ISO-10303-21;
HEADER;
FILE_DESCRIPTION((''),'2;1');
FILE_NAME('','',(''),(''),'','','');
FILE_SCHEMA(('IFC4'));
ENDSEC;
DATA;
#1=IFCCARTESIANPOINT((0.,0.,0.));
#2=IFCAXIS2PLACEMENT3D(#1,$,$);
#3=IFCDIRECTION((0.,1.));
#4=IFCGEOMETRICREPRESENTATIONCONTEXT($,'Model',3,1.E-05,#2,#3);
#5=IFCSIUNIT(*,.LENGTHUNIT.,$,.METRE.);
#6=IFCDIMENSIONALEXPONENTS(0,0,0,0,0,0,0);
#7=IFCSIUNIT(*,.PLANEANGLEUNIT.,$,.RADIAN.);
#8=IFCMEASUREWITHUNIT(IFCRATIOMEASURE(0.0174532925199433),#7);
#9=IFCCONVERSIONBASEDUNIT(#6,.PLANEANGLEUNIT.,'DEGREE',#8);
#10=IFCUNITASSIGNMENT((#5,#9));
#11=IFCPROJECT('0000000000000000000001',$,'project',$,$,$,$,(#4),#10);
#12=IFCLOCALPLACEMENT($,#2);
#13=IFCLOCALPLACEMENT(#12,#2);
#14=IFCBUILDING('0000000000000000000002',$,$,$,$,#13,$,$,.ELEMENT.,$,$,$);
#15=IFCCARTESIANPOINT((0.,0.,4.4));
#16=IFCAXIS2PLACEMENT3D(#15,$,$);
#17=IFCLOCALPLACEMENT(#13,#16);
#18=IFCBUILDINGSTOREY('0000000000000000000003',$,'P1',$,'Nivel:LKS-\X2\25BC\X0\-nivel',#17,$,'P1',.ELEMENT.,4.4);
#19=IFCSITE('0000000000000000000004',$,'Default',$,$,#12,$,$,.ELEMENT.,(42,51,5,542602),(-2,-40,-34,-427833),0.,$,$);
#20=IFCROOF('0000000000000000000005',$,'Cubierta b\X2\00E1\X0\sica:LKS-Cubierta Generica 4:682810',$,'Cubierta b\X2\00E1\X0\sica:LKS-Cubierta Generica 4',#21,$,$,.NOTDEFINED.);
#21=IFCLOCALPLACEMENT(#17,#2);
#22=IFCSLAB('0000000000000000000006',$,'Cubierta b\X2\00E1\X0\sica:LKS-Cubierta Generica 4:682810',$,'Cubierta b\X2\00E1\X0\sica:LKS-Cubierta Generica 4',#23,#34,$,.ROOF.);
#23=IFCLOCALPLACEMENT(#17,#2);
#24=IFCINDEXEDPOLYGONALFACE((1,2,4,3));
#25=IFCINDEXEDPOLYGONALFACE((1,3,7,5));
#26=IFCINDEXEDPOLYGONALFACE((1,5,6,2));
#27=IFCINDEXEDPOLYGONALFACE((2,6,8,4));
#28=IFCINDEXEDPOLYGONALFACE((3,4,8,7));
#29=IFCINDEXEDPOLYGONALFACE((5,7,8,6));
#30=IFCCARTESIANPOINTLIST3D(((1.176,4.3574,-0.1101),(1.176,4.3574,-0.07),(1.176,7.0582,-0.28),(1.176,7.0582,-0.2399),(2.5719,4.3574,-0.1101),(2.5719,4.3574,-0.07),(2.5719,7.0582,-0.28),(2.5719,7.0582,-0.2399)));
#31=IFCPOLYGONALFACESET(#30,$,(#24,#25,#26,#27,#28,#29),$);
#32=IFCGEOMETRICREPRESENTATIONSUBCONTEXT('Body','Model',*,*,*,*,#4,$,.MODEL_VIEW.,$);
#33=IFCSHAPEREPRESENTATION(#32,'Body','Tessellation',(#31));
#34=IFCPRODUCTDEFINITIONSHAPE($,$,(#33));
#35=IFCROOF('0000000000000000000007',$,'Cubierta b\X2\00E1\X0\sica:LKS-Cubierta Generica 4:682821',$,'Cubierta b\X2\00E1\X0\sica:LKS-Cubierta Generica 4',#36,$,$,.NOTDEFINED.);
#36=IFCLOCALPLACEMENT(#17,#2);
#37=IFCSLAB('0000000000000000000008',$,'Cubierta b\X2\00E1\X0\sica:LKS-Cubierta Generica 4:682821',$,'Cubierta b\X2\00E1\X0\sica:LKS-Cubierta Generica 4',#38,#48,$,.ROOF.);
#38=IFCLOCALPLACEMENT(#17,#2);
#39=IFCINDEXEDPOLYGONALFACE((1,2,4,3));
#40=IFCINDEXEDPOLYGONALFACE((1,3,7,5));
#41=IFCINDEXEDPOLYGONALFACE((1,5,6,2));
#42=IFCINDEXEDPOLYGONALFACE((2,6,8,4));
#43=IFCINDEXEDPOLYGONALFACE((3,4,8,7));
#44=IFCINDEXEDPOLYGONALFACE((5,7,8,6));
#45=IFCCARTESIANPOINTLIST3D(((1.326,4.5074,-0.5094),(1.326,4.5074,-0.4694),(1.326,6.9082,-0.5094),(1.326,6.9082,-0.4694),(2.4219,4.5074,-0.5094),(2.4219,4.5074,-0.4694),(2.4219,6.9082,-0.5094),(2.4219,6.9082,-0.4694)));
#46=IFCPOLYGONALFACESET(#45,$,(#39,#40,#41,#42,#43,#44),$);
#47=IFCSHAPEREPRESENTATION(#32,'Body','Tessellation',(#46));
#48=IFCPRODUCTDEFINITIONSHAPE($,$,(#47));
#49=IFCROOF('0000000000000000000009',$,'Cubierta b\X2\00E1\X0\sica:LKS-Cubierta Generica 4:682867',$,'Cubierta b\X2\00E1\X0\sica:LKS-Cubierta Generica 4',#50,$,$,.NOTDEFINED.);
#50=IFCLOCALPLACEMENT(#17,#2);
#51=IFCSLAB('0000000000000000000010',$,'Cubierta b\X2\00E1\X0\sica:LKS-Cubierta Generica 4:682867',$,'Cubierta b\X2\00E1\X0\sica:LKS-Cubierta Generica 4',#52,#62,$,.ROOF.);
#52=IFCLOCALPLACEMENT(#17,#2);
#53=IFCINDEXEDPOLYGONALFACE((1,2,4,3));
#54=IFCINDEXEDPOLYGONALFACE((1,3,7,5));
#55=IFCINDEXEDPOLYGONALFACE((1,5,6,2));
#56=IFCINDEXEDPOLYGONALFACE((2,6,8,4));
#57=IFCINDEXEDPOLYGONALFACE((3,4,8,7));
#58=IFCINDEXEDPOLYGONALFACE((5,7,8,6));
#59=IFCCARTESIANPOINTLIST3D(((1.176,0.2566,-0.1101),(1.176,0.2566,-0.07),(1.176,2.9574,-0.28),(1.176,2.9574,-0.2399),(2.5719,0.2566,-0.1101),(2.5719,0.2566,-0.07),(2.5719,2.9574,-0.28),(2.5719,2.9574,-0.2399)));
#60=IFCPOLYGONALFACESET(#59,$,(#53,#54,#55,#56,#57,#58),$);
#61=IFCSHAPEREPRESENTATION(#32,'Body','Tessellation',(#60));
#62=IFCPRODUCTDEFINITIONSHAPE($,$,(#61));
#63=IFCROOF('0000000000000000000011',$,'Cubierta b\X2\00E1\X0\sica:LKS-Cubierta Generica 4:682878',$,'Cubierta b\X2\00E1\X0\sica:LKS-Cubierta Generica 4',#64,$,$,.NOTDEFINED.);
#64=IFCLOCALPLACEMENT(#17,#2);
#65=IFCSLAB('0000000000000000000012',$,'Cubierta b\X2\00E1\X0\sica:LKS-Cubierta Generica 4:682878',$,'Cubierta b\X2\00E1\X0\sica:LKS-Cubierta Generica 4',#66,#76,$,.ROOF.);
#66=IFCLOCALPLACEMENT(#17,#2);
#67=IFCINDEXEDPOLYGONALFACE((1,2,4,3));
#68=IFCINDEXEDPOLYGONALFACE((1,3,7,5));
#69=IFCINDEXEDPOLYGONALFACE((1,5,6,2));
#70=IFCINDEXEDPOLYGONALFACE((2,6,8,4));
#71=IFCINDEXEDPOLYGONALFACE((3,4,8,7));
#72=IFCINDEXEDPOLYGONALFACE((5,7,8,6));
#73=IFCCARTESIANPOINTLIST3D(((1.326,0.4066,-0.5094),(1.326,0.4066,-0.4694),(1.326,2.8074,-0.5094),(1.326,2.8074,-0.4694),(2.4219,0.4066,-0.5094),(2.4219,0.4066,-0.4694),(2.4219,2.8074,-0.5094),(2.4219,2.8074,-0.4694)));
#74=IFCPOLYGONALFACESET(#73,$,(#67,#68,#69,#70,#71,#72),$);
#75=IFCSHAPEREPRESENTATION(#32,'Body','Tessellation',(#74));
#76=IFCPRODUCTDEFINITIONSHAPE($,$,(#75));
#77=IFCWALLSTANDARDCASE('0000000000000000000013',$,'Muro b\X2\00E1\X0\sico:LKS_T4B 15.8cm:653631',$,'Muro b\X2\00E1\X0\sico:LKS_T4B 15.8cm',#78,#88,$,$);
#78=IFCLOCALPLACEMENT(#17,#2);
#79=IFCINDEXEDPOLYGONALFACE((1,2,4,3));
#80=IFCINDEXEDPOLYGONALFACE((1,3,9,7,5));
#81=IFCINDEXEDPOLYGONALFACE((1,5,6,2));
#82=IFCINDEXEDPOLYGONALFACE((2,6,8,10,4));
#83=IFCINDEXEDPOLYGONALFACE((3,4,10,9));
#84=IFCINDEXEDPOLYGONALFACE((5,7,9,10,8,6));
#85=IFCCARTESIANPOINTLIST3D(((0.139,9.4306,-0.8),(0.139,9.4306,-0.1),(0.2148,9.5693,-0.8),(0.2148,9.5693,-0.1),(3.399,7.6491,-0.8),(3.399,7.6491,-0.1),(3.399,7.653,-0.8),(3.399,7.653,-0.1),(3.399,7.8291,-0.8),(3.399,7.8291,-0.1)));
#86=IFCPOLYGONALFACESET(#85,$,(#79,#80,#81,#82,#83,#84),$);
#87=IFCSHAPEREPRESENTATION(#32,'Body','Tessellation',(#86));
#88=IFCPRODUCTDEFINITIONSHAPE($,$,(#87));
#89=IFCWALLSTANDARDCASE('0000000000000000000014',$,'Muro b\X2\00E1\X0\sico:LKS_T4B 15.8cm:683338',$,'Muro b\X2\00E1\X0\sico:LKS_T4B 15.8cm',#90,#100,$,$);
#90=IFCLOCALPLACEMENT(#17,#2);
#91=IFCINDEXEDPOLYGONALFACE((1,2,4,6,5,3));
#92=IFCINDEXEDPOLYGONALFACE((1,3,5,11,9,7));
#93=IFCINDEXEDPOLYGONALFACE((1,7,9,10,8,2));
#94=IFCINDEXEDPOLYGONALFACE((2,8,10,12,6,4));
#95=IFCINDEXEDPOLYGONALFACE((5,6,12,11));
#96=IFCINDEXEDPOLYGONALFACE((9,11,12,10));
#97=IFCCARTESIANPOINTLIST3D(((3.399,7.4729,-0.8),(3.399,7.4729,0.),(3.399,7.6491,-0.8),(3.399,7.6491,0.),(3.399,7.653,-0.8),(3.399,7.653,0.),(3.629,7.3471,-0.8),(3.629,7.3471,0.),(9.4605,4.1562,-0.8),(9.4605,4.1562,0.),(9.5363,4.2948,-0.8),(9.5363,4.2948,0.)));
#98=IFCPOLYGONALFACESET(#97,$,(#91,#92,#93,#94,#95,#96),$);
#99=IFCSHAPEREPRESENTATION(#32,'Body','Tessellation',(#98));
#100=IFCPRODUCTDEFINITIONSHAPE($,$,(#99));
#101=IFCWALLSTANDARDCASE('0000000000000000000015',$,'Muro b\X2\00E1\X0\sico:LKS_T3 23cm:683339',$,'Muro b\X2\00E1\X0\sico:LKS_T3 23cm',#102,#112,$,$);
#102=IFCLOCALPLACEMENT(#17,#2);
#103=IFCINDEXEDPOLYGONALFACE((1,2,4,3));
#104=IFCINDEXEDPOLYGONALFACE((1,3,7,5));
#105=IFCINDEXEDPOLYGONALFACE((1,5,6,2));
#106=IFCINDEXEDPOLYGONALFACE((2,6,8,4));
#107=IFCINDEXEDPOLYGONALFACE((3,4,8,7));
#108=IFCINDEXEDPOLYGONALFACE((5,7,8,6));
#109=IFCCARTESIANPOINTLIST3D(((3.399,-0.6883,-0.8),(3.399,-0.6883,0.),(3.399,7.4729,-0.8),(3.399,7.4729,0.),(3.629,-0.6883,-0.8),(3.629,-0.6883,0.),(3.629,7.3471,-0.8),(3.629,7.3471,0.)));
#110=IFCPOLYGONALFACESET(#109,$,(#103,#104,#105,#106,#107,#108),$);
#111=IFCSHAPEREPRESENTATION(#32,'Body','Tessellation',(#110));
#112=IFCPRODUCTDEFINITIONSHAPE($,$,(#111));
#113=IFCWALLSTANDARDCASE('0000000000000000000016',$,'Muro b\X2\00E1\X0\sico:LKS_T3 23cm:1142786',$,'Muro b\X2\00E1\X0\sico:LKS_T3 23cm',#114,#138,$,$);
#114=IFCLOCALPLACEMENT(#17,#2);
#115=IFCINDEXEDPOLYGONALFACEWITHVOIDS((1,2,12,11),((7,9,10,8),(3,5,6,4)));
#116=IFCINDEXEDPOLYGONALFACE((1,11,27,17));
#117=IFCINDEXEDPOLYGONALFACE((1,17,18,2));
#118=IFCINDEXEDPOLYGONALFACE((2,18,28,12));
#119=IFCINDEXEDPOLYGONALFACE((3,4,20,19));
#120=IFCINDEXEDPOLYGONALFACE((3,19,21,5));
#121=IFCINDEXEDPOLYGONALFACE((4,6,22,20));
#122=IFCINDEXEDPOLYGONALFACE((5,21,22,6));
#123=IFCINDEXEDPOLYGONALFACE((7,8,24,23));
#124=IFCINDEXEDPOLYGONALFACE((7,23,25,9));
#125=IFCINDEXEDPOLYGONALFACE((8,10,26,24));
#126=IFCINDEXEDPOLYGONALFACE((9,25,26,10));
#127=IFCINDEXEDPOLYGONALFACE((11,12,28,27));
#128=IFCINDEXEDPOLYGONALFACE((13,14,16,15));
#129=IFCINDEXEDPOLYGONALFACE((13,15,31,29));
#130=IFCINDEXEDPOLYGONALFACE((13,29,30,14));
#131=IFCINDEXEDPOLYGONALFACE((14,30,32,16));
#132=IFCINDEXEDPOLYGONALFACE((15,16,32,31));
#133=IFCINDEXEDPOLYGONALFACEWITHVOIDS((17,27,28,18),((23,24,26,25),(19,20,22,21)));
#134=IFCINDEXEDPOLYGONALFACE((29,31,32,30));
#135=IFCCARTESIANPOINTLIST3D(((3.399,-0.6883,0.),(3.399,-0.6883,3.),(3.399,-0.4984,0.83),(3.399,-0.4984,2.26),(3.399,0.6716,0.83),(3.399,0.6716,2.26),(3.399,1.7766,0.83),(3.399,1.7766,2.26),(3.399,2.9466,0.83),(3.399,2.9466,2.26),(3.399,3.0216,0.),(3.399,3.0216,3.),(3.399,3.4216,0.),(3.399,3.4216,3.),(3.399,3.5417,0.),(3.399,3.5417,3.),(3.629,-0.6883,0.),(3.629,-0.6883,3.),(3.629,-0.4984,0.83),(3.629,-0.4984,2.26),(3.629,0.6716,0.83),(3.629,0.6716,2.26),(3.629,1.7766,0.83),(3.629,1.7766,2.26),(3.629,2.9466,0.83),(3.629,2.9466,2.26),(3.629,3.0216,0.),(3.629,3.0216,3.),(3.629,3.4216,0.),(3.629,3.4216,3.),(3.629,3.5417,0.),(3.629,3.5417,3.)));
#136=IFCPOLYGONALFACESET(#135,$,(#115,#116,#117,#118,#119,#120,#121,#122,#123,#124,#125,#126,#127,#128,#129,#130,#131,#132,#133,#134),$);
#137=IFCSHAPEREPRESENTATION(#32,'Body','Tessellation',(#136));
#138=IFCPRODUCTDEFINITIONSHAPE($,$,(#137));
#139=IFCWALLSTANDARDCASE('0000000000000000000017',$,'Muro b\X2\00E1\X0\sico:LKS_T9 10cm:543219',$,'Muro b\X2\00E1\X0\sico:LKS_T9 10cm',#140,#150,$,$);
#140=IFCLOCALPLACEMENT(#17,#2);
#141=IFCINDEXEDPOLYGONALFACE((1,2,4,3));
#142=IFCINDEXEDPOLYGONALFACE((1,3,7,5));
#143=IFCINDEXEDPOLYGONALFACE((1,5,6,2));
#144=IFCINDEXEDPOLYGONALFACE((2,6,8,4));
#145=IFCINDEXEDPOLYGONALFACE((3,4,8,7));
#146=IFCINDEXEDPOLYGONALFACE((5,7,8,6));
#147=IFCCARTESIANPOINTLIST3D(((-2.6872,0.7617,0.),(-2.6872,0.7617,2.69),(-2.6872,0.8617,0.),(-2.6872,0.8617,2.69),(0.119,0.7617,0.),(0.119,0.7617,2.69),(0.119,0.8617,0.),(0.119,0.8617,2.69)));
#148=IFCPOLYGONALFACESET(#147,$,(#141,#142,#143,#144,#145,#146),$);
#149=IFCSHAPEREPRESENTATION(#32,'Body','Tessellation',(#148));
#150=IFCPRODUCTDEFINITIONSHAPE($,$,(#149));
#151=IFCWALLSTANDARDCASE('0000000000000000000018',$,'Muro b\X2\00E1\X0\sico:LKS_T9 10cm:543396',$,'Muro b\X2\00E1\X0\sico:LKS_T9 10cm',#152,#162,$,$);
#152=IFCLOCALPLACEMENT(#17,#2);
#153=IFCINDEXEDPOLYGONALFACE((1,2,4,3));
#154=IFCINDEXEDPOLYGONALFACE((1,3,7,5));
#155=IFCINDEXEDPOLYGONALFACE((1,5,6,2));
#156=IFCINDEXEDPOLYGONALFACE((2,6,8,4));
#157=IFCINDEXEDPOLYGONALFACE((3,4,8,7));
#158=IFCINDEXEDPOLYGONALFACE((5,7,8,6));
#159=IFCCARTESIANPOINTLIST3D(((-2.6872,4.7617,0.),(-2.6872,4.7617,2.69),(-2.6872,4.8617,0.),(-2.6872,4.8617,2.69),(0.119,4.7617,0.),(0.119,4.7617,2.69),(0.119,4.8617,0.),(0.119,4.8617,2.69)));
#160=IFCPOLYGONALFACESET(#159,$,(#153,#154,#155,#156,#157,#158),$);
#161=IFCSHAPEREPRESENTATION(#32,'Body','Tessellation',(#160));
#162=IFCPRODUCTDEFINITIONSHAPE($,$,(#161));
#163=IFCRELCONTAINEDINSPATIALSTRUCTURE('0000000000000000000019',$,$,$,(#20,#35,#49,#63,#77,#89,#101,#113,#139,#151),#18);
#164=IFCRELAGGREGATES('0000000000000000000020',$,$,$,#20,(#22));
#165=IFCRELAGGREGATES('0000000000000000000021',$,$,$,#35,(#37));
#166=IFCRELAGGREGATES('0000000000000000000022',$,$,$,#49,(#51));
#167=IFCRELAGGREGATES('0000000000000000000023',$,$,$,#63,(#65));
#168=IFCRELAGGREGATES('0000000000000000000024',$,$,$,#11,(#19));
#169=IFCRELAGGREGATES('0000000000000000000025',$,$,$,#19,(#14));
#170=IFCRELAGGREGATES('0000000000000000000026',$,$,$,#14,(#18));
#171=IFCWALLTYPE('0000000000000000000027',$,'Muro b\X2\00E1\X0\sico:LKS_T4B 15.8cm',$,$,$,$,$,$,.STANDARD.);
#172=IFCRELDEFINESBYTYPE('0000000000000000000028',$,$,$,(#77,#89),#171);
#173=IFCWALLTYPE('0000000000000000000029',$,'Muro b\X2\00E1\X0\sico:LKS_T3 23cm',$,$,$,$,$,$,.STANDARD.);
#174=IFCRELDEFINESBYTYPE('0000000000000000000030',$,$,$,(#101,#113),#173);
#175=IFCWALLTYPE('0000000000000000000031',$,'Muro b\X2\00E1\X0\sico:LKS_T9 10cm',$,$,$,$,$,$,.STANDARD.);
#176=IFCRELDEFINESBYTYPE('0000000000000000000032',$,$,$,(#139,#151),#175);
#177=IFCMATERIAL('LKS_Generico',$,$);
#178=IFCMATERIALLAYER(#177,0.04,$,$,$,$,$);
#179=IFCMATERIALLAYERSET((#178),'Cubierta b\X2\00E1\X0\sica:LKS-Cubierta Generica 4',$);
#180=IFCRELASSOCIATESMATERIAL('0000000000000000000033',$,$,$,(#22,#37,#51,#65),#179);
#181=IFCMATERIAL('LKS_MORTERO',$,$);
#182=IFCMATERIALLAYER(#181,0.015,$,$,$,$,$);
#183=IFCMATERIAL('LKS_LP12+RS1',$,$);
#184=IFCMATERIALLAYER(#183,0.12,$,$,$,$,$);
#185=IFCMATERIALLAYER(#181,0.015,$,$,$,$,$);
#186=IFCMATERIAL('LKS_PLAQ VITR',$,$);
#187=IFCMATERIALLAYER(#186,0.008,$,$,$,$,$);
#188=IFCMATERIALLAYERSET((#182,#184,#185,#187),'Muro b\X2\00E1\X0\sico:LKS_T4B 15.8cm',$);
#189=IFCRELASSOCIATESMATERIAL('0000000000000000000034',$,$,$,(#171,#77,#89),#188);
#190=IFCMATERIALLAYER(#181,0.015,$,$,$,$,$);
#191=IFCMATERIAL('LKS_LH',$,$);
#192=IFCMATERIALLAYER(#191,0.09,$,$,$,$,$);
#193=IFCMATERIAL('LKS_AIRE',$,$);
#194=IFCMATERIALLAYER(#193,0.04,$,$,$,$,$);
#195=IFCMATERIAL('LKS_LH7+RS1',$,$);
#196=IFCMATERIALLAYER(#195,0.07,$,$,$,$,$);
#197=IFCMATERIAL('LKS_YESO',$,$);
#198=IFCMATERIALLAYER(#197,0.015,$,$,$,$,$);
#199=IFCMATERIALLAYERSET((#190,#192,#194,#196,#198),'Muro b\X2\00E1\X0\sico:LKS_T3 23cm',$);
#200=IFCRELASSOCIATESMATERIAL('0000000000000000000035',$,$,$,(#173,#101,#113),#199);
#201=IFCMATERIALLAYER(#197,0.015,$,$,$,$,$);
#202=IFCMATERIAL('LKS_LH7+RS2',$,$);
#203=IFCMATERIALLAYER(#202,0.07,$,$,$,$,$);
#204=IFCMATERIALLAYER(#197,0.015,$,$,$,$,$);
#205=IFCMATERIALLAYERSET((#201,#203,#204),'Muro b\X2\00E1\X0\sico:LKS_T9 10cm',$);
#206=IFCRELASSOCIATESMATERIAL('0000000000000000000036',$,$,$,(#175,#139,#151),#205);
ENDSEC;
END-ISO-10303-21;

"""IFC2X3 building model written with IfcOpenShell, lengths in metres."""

from ifc_helpers import new_model, entity, si_unit, converted_unit, direction, frame, frame_2d, origin, origin_2d_with_axis, place, context, subcontext, project, spatial, polyline, rectangle, outline, extrude, material, layer, layer_set, layer_usage, type_object, element, aggregate, save


model = new_model("IFC2X3")

# Units and contexts
model_context = context("Model", 3, precision=1e-05, world=origin(), true_north=direction((0.0, 1.0)))
body_context = subcontext(model_context, "Body", "Model", "MODEL_VIEW")
ifc_project = project(units=[si_unit("LENGTHUNIT", "METRE"), converted_unit("PLANEANGLEUNIT", "DEGREE", entity("IfcRatioMeasure", 0.0174532925199433), si_unit("PLANEANGLEUNIT", "RADIAN"), dimensions=[0, 0, 0, 0, 0, 0, 0])], contexts=[model_context])

# Site, building, storey
site_placement = place(None, origin())
site = spatial("IfcSite", under=ifc_project, at=site_placement, Name="Default", CompositionType="ELEMENT", RefLatitude=(42, 51, 5, 542602), RefLongitude=(-2, -40, -34, -427833), RefElevation=0.0)
building_placement = place(site_placement, origin())
building = spatial("IfcBuilding", under=site, at=building_placement, CompositionType="ELEMENT")
storey_placement = place(building_placement, frame((0.0, 0.0, 4.4)))
storey = spatial("IfcBuildingStorey", under=building, at=storey_placement, Name="P1", ObjectType="Nivel:LKS-▼-nivel", LongName="P1", CompositionType="ELEMENT", Elevation=4.4)

# Roofs, slabs
roof_1_placement = place(storey_placement, frame((1.176, 4.3574, -0.28)))
roof_1 = element("IfcRoof", 1, at=roof_1_placement, inside=storey, Name="Cubierta básica:LKS-Cubierta Generica 4:682810", ObjectType="Cubierta básica:LKS-Cubierta Generica 4", ShapeType="NOTDEFINED")
ifc_material_1 = material(Name="LKS_Generico")
ifc_layer_1 = layer(ifc_material_1, 0.04)
ifc_layer_set_1 = layer_set([ifc_layer_1], Name="Cubierta básica:LKS-Cubierta Generica 4")
slab_1_placement = place(roof_1_placement, origin())
slab_1 = element("IfcSlab", 2, at=slab_1_placement, material=ifc_layer_set_1, Name="Cubierta básica:LKS-Cubierta Generica 4:682810", ObjectType="Cubierta básica:LKS-Cubierta Generica 4", PredefinedType="ROOF", context=body_context, shape_type="SweptSolid", body=[
    extrude(rectangle(XDim=1.3959, YDim=2.7061, at=frame_2d((0.0, 0.0), x_axis=(1.0, 0.0))), frame((0.6979, 1.3504, 0.085), z_axis=(0.0, 0.062791, 0.998027), x_axis=(1.0, 0.0, 0.0)), (0.0, -0.062791, 0.998027), 0.0401),
])
aggregate(roof_1, [slab_1])
roof_2_placement = place(storey_placement, frame((1.326, 4.5074, -0.5094)))
roof_2 = element("IfcRoof", 3, at=roof_2_placement, inside=storey, Name="Cubierta básica:LKS-Cubierta Generica 4:682821", ObjectType="Cubierta básica:LKS-Cubierta Generica 4", ShapeType="NOTDEFINED")
slab_2_placement = place(roof_2_placement, origin())
slab_2 = element("IfcSlab", 4, at=slab_2_placement, material=ifc_layer_set_1, Name="Cubierta básica:LKS-Cubierta Generica 4:682821", ObjectType="Cubierta básica:LKS-Cubierta Generica 4", PredefinedType="ROOF", context=body_context, shape_type="SweptSolid", body=[
    extrude(rectangle(XDim=1.0959, YDim=2.4008, at=frame_2d((0.0, 0.0), x_axis=(1.0, 0.0))), frame((0.5479, 1.2004, 0.0)), (0.0, 0.0, 1.0), 0.04),
])
aggregate(roof_2, [slab_2])
roof_3_placement = place(storey_placement, frame((1.176, 0.2566, -0.28)))
roof_3 = element("IfcRoof", 5, at=roof_3_placement, inside=storey, Name="Cubierta básica:LKS-Cubierta Generica 4:682867", ObjectType="Cubierta básica:LKS-Cubierta Generica 4", ShapeType="NOTDEFINED")
slab_3_placement = place(roof_3_placement, origin())
slab_3 = element("IfcSlab", 6, at=slab_3_placement, material=ifc_layer_set_1, Name="Cubierta básica:LKS-Cubierta Generica 4:682867", ObjectType="Cubierta básica:LKS-Cubierta Generica 4", PredefinedType="ROOF", context=body_context, shape_type="SweptSolid", body=[
    extrude(rectangle(XDim=1.3959, YDim=2.7061, at=origin_2d_with_axis()), frame((0.6979, 1.3504, 0.085), z_axis=(0.0, 0.062791, 0.998027), x_axis=(1.0, 0.0, 0.0)), (0.0, -0.062791, 0.998027), 0.0401),
])
aggregate(roof_3, [slab_3])
roof_4_placement = place(storey_placement, frame((1.326, 0.4066, -0.5094)))
roof_4 = element("IfcRoof", 7, at=roof_4_placement, inside=storey, Name="Cubierta básica:LKS-Cubierta Generica 4:682878", ObjectType="Cubierta básica:LKS-Cubierta Generica 4", ShapeType="NOTDEFINED")
slab_4_placement = place(roof_4_placement, origin())
slab_4 = element("IfcSlab", 8, at=slab_4_placement, material=ifc_layer_set_1, Name="Cubierta básica:LKS-Cubierta Generica 4:682878", ObjectType="Cubierta básica:LKS-Cubierta Generica 4", PredefinedType="ROOF", context=body_context, shape_type="SweptSolid", body=[
    extrude(rectangle(XDim=1.0959, YDim=2.4008, at=origin_2d_with_axis()), frame((0.5479, 1.2004, 0.0)), (0.0, 0.0, 1.0), 0.04),
])
aggregate(roof_4, [slab_4])

# Shared definitions
ifc_material_2 = material(Name="LKS_MORTERO")
ifc_layer_2 = layer(ifc_material_2, 0.015)
ifc_material_3 = material(Name="LKS_LP12+RS1")
ifc_layer_3 = layer(ifc_material_3, 0.12)
ifc_layer_4 = layer(ifc_material_2, 0.015)
ifc_material_4 = material(Name="LKS_PLAQ VITR")
ifc_layer_5 = layer(ifc_material_4, 0.008)
ifc_layer_set_2 = layer_set([ifc_layer_2, ifc_layer_3, ifc_layer_4, ifc_layer_5], Name="Muro básico:LKS_T4B 15.8cm")
wall_type_1 = type_object("IfcWallType", Name="Muro básico:LKS_T4B 15.8cm", PredefinedType="STANDARD", material=ifc_layer_set_2)

# Walls
ifc_layer_usage_1 = layer_usage(ifc_layer_set_2, "AXIS2", "POSITIVE", -0.079)
wall_1_placement = place(storey_placement, frame((0.1769, 9.5, -0.8), z_axis=(0.0, 0.0, 1.0), x_axis=(0.877509, -0.479561, 0.0)))
element("IfcWallStandardCase", 9, at=wall_1_placement, inside=storey, type_object=wall_type_1, material=ifc_layer_usage_1, Name="Muro básico:LKS_T4B 15.8cm:653631", ObjectType="Muro básico:LKS_T4B 15.8cm", context=body_context, shape_type="SweptSolid", body=[
    extrude(outline(polyline([(3.715, -0.079), (3.7131, -0.0755), (3.6286, 0.079), (0.0, 0.079), (0.0, -0.079), (3.715, -0.079)])), origin(), (0.0, 0.0, 1.0), 0.7),
])
ifc_layer_usage_2 = layer_usage(ifc_layer_set_2, "AXIS2", "POSITIVE", -0.079)
wall_2_placement = place(storey_placement, frame((9.4984, 4.2255, -0.8), z_axis=(0.0, 0.0, 1.0), x_axis=(-0.877256, 0.480022, 0.0)))
element("IfcWallStandardCase", 10, at=wall_2_placement, inside=storey, type_object=wall_type_1, material=ifc_layer_usage_2, Name="Muro básico:LKS_T4B 15.8cm:683338", ObjectType="Muro básico:LKS_T4B 15.8cm", context=body_context, shape_type="SweptSolid", body=[
    extrude(outline(polyline([(6.9961, -0.079), (6.9942, -0.0755), (6.9096, 0.079), (6.6474, 0.079), (0.0, 0.079), (0.0, -0.079), (6.9961, -0.079)])), origin(), (0.0, 0.0, 1.0), 0.8),
])
ifc_layer_6 = layer(ifc_material_2, 0.015)
ifc_material_5 = material(Name="LKS_LH")
ifc_layer_7 = layer(ifc_material_5, 0.09)
ifc_material_6 = material(Name="LKS_AIRE")
ifc_layer_8 = layer(ifc_material_6, 0.04)
ifc_material_7 = material(Name="LKS_LH7+RS1")
ifc_layer_9 = layer(ifc_material_7, 0.07)
ifc_material_8 = material(Name="LKS_YESO")
ifc_layer_10 = layer(ifc_material_8, 0.015)
ifc_layer_set_3 = layer_set([ifc_layer_6, ifc_layer_7, ifc_layer_8, ifc_layer_9, ifc_layer_10], Name="Muro básico:LKS_T3 23cm")
ifc_layer_usage_3 = layer_usage(ifc_layer_set_3, "AXIS2", "POSITIVE", -0.115)
wall_type_2 = type_object("IfcWallType", Name="Muro básico:LKS_T3 23cm", PredefinedType="STANDARD", material=ifc_layer_set_3)
wall_3_placement = place(storey_placement, frame((3.514, 7.4729, -0.8), z_axis=(0.0, 0.0, 1.0), x_axis=(0.0, -1.0, 0.0)))
element("IfcWallStandardCase", 11, at=wall_3_placement, inside=storey, type_object=wall_type_2, material=ifc_layer_usage_3, Name="Muro básico:LKS_T3 23cm:683339", ObjectType="Muro básico:LKS_T3 23cm", context=body_context, shape_type="SweptSolid", body=[
    extrude(outline(polyline([(8.1612, -0.115), (8.1612, 0.115), (0.1259, 0.115), (0.0, -0.115), (8.1612, -0.115)])), origin(), (0.0, 0.0, 1.0), 0.8),
])

# Wall, openings
ifc_layer_usage_4 = layer_usage(ifc_layer_set_3, "AXIS2", "POSITIVE", -0.115)
wall_4_placement = place(storey_placement, frame((3.514, 3.5417, 0.0), z_axis=(0.0, 0.0, 1.0), x_axis=(0.0, -1.0, 0.0)))
wall_4 = element("IfcWallStandardCase", 12, at=wall_4_placement, inside=storey, type_object=wall_type_2, material=ifc_layer_usage_4, Name="Muro básico:LKS_T3 23cm:1142786", ObjectType="Muro básico:LKS_T3 23cm", context=body_context, shape_type="SweptSolid", body=[
    extrude(rectangle(XDim=4.23, YDim=0.23, at=frame_2d((2.115, 0.0), x_axis=(1.0, 0.0))), origin(), (0.0, 0.0, 1.0), 3.0),
])
opening_1_placement = place(storey_placement, frame((3.514, 3.5417, 0.0), z_axis=(0.0, 0.0, 1.0), x_axis=(0.0, -1.0, 0.0)))
element("IfcOpeningElement", 13, at=opening_1_placement, cuts=wall_4, ObjectType="Opening", context=body_context, shape_type="SweptSolid", body=[
    extrude(rectangle(XDim=3.0, YDim=0.23, at=frame_2d((-0.3, 0.0132), x_axis=(1.0, 0.0))), frame((0.5201, -0.0132, 1.8), z_axis=(-1.0, 0.0, 0.0), x_axis=(0.0, 0.0, 1.0)), (0.0, 0.0, 1.0), 0.4),
])
opening_2_placement = place(wall_4_placement, frame((4.0401, 0.115, 0.83)))
element("IfcOpeningElement", 14, at=opening_2_placement, cuts=wall_4, ObjectType="Opening", context=body_context, shape_type="SweptSolid", body=[
    extrude(rectangle(XDim=1.43, YDim=1.17, at=frame_2d((0.715, 0.585), x_axis=(1.0, 0.0))), frame((0.0, 0.0, 0.0), z_axis=(0.0, -1.0, 0.0), x_axis=(0.0, 0.0, 1.0)), (0.0, 0.0, 1.0), 0.23),
])
opening_3_placement = place(wall_4_placement, frame((1.7651, 0.115, 0.83)))
element("IfcOpeningElement", 15, at=opening_3_placement, cuts=wall_4, ObjectType="Opening", context=body_context, shape_type="SweptSolid", body=[
    extrude(rectangle(XDim=1.43, YDim=1.17, at=frame_2d((0.715, 0.585), x_axis=(1.0, 0.0))), frame((0.0, 0.0, 0.0), z_axis=(0.0, -1.0, 0.0), x_axis=(0.0, 0.0, 1.0)), (0.0, 0.0, 1.0), 0.23),
])

# Walls
ifc_layer_11 = layer(ifc_material_8, 0.015)
ifc_material_9 = material(Name="LKS_LH7+RS2")
ifc_layer_12 = layer(ifc_material_9, 0.07)
ifc_layer_13 = layer(ifc_material_8, 0.015)
ifc_layer_set_4 = layer_set([ifc_layer_11, ifc_layer_12, ifc_layer_13], Name="Muro básico:LKS_T9 10cm")
ifc_layer_usage_5 = layer_usage(ifc_layer_set_4, "AXIS2", "NEGATIVE", 0.05)
wall_type_3 = type_object("IfcWallType", Name="Muro básico:LKS_T9 10cm", PredefinedType="STANDARD", material=ifc_layer_set_4)
wall_5_placement = place(storey_placement, frame((0.119, 0.8117, 0.0), z_axis=(0.0, 0.0, 1.0), x_axis=(-1.0, 0.0, 0.0)))
element("IfcWallStandardCase", 16, at=wall_5_placement, inside=storey, type_object=wall_type_3, material=ifc_layer_usage_5, Name="Muro básico:LKS_T9 10cm:543219", ObjectType="Muro básico:LKS_T9 10cm", context=body_context, shape_type="SweptSolid", body=[
    extrude(rectangle(XDim=2.8061, YDim=0.1, at=frame_2d((1.4031, 0.0), x_axis=(-1.0, 0.0))), origin(), (0.0, 0.0, 1.0), 2.69),
])
ifc_layer_usage_6 = layer_usage(ifc_layer_set_4, "AXIS2", "NEGATIVE", 0.05)
wall_6_placement = place(storey_placement, frame((0.119, 4.8117, 0.0), z_axis=(0.0, 0.0, 1.0), x_axis=(-1.0, 0.0, 0.0)))
element("IfcWallStandardCase", 17, at=wall_6_placement, inside=storey, type_object=wall_type_3, material=ifc_layer_usage_6, Name="Muro básico:LKS_T9 10cm:543396", ObjectType="Muro básico:LKS_T9 10cm", context=body_context, shape_type="SweptSolid", body=[
    extrude(rectangle(XDim=2.8061, YDim=0.1, at=frame_2d((1.4031, 0.0), x_axis=(-1.0, 0.0))), origin(), (0.0, 0.0, 1.0), 2.69),
])

save(model, "model.ifc")
